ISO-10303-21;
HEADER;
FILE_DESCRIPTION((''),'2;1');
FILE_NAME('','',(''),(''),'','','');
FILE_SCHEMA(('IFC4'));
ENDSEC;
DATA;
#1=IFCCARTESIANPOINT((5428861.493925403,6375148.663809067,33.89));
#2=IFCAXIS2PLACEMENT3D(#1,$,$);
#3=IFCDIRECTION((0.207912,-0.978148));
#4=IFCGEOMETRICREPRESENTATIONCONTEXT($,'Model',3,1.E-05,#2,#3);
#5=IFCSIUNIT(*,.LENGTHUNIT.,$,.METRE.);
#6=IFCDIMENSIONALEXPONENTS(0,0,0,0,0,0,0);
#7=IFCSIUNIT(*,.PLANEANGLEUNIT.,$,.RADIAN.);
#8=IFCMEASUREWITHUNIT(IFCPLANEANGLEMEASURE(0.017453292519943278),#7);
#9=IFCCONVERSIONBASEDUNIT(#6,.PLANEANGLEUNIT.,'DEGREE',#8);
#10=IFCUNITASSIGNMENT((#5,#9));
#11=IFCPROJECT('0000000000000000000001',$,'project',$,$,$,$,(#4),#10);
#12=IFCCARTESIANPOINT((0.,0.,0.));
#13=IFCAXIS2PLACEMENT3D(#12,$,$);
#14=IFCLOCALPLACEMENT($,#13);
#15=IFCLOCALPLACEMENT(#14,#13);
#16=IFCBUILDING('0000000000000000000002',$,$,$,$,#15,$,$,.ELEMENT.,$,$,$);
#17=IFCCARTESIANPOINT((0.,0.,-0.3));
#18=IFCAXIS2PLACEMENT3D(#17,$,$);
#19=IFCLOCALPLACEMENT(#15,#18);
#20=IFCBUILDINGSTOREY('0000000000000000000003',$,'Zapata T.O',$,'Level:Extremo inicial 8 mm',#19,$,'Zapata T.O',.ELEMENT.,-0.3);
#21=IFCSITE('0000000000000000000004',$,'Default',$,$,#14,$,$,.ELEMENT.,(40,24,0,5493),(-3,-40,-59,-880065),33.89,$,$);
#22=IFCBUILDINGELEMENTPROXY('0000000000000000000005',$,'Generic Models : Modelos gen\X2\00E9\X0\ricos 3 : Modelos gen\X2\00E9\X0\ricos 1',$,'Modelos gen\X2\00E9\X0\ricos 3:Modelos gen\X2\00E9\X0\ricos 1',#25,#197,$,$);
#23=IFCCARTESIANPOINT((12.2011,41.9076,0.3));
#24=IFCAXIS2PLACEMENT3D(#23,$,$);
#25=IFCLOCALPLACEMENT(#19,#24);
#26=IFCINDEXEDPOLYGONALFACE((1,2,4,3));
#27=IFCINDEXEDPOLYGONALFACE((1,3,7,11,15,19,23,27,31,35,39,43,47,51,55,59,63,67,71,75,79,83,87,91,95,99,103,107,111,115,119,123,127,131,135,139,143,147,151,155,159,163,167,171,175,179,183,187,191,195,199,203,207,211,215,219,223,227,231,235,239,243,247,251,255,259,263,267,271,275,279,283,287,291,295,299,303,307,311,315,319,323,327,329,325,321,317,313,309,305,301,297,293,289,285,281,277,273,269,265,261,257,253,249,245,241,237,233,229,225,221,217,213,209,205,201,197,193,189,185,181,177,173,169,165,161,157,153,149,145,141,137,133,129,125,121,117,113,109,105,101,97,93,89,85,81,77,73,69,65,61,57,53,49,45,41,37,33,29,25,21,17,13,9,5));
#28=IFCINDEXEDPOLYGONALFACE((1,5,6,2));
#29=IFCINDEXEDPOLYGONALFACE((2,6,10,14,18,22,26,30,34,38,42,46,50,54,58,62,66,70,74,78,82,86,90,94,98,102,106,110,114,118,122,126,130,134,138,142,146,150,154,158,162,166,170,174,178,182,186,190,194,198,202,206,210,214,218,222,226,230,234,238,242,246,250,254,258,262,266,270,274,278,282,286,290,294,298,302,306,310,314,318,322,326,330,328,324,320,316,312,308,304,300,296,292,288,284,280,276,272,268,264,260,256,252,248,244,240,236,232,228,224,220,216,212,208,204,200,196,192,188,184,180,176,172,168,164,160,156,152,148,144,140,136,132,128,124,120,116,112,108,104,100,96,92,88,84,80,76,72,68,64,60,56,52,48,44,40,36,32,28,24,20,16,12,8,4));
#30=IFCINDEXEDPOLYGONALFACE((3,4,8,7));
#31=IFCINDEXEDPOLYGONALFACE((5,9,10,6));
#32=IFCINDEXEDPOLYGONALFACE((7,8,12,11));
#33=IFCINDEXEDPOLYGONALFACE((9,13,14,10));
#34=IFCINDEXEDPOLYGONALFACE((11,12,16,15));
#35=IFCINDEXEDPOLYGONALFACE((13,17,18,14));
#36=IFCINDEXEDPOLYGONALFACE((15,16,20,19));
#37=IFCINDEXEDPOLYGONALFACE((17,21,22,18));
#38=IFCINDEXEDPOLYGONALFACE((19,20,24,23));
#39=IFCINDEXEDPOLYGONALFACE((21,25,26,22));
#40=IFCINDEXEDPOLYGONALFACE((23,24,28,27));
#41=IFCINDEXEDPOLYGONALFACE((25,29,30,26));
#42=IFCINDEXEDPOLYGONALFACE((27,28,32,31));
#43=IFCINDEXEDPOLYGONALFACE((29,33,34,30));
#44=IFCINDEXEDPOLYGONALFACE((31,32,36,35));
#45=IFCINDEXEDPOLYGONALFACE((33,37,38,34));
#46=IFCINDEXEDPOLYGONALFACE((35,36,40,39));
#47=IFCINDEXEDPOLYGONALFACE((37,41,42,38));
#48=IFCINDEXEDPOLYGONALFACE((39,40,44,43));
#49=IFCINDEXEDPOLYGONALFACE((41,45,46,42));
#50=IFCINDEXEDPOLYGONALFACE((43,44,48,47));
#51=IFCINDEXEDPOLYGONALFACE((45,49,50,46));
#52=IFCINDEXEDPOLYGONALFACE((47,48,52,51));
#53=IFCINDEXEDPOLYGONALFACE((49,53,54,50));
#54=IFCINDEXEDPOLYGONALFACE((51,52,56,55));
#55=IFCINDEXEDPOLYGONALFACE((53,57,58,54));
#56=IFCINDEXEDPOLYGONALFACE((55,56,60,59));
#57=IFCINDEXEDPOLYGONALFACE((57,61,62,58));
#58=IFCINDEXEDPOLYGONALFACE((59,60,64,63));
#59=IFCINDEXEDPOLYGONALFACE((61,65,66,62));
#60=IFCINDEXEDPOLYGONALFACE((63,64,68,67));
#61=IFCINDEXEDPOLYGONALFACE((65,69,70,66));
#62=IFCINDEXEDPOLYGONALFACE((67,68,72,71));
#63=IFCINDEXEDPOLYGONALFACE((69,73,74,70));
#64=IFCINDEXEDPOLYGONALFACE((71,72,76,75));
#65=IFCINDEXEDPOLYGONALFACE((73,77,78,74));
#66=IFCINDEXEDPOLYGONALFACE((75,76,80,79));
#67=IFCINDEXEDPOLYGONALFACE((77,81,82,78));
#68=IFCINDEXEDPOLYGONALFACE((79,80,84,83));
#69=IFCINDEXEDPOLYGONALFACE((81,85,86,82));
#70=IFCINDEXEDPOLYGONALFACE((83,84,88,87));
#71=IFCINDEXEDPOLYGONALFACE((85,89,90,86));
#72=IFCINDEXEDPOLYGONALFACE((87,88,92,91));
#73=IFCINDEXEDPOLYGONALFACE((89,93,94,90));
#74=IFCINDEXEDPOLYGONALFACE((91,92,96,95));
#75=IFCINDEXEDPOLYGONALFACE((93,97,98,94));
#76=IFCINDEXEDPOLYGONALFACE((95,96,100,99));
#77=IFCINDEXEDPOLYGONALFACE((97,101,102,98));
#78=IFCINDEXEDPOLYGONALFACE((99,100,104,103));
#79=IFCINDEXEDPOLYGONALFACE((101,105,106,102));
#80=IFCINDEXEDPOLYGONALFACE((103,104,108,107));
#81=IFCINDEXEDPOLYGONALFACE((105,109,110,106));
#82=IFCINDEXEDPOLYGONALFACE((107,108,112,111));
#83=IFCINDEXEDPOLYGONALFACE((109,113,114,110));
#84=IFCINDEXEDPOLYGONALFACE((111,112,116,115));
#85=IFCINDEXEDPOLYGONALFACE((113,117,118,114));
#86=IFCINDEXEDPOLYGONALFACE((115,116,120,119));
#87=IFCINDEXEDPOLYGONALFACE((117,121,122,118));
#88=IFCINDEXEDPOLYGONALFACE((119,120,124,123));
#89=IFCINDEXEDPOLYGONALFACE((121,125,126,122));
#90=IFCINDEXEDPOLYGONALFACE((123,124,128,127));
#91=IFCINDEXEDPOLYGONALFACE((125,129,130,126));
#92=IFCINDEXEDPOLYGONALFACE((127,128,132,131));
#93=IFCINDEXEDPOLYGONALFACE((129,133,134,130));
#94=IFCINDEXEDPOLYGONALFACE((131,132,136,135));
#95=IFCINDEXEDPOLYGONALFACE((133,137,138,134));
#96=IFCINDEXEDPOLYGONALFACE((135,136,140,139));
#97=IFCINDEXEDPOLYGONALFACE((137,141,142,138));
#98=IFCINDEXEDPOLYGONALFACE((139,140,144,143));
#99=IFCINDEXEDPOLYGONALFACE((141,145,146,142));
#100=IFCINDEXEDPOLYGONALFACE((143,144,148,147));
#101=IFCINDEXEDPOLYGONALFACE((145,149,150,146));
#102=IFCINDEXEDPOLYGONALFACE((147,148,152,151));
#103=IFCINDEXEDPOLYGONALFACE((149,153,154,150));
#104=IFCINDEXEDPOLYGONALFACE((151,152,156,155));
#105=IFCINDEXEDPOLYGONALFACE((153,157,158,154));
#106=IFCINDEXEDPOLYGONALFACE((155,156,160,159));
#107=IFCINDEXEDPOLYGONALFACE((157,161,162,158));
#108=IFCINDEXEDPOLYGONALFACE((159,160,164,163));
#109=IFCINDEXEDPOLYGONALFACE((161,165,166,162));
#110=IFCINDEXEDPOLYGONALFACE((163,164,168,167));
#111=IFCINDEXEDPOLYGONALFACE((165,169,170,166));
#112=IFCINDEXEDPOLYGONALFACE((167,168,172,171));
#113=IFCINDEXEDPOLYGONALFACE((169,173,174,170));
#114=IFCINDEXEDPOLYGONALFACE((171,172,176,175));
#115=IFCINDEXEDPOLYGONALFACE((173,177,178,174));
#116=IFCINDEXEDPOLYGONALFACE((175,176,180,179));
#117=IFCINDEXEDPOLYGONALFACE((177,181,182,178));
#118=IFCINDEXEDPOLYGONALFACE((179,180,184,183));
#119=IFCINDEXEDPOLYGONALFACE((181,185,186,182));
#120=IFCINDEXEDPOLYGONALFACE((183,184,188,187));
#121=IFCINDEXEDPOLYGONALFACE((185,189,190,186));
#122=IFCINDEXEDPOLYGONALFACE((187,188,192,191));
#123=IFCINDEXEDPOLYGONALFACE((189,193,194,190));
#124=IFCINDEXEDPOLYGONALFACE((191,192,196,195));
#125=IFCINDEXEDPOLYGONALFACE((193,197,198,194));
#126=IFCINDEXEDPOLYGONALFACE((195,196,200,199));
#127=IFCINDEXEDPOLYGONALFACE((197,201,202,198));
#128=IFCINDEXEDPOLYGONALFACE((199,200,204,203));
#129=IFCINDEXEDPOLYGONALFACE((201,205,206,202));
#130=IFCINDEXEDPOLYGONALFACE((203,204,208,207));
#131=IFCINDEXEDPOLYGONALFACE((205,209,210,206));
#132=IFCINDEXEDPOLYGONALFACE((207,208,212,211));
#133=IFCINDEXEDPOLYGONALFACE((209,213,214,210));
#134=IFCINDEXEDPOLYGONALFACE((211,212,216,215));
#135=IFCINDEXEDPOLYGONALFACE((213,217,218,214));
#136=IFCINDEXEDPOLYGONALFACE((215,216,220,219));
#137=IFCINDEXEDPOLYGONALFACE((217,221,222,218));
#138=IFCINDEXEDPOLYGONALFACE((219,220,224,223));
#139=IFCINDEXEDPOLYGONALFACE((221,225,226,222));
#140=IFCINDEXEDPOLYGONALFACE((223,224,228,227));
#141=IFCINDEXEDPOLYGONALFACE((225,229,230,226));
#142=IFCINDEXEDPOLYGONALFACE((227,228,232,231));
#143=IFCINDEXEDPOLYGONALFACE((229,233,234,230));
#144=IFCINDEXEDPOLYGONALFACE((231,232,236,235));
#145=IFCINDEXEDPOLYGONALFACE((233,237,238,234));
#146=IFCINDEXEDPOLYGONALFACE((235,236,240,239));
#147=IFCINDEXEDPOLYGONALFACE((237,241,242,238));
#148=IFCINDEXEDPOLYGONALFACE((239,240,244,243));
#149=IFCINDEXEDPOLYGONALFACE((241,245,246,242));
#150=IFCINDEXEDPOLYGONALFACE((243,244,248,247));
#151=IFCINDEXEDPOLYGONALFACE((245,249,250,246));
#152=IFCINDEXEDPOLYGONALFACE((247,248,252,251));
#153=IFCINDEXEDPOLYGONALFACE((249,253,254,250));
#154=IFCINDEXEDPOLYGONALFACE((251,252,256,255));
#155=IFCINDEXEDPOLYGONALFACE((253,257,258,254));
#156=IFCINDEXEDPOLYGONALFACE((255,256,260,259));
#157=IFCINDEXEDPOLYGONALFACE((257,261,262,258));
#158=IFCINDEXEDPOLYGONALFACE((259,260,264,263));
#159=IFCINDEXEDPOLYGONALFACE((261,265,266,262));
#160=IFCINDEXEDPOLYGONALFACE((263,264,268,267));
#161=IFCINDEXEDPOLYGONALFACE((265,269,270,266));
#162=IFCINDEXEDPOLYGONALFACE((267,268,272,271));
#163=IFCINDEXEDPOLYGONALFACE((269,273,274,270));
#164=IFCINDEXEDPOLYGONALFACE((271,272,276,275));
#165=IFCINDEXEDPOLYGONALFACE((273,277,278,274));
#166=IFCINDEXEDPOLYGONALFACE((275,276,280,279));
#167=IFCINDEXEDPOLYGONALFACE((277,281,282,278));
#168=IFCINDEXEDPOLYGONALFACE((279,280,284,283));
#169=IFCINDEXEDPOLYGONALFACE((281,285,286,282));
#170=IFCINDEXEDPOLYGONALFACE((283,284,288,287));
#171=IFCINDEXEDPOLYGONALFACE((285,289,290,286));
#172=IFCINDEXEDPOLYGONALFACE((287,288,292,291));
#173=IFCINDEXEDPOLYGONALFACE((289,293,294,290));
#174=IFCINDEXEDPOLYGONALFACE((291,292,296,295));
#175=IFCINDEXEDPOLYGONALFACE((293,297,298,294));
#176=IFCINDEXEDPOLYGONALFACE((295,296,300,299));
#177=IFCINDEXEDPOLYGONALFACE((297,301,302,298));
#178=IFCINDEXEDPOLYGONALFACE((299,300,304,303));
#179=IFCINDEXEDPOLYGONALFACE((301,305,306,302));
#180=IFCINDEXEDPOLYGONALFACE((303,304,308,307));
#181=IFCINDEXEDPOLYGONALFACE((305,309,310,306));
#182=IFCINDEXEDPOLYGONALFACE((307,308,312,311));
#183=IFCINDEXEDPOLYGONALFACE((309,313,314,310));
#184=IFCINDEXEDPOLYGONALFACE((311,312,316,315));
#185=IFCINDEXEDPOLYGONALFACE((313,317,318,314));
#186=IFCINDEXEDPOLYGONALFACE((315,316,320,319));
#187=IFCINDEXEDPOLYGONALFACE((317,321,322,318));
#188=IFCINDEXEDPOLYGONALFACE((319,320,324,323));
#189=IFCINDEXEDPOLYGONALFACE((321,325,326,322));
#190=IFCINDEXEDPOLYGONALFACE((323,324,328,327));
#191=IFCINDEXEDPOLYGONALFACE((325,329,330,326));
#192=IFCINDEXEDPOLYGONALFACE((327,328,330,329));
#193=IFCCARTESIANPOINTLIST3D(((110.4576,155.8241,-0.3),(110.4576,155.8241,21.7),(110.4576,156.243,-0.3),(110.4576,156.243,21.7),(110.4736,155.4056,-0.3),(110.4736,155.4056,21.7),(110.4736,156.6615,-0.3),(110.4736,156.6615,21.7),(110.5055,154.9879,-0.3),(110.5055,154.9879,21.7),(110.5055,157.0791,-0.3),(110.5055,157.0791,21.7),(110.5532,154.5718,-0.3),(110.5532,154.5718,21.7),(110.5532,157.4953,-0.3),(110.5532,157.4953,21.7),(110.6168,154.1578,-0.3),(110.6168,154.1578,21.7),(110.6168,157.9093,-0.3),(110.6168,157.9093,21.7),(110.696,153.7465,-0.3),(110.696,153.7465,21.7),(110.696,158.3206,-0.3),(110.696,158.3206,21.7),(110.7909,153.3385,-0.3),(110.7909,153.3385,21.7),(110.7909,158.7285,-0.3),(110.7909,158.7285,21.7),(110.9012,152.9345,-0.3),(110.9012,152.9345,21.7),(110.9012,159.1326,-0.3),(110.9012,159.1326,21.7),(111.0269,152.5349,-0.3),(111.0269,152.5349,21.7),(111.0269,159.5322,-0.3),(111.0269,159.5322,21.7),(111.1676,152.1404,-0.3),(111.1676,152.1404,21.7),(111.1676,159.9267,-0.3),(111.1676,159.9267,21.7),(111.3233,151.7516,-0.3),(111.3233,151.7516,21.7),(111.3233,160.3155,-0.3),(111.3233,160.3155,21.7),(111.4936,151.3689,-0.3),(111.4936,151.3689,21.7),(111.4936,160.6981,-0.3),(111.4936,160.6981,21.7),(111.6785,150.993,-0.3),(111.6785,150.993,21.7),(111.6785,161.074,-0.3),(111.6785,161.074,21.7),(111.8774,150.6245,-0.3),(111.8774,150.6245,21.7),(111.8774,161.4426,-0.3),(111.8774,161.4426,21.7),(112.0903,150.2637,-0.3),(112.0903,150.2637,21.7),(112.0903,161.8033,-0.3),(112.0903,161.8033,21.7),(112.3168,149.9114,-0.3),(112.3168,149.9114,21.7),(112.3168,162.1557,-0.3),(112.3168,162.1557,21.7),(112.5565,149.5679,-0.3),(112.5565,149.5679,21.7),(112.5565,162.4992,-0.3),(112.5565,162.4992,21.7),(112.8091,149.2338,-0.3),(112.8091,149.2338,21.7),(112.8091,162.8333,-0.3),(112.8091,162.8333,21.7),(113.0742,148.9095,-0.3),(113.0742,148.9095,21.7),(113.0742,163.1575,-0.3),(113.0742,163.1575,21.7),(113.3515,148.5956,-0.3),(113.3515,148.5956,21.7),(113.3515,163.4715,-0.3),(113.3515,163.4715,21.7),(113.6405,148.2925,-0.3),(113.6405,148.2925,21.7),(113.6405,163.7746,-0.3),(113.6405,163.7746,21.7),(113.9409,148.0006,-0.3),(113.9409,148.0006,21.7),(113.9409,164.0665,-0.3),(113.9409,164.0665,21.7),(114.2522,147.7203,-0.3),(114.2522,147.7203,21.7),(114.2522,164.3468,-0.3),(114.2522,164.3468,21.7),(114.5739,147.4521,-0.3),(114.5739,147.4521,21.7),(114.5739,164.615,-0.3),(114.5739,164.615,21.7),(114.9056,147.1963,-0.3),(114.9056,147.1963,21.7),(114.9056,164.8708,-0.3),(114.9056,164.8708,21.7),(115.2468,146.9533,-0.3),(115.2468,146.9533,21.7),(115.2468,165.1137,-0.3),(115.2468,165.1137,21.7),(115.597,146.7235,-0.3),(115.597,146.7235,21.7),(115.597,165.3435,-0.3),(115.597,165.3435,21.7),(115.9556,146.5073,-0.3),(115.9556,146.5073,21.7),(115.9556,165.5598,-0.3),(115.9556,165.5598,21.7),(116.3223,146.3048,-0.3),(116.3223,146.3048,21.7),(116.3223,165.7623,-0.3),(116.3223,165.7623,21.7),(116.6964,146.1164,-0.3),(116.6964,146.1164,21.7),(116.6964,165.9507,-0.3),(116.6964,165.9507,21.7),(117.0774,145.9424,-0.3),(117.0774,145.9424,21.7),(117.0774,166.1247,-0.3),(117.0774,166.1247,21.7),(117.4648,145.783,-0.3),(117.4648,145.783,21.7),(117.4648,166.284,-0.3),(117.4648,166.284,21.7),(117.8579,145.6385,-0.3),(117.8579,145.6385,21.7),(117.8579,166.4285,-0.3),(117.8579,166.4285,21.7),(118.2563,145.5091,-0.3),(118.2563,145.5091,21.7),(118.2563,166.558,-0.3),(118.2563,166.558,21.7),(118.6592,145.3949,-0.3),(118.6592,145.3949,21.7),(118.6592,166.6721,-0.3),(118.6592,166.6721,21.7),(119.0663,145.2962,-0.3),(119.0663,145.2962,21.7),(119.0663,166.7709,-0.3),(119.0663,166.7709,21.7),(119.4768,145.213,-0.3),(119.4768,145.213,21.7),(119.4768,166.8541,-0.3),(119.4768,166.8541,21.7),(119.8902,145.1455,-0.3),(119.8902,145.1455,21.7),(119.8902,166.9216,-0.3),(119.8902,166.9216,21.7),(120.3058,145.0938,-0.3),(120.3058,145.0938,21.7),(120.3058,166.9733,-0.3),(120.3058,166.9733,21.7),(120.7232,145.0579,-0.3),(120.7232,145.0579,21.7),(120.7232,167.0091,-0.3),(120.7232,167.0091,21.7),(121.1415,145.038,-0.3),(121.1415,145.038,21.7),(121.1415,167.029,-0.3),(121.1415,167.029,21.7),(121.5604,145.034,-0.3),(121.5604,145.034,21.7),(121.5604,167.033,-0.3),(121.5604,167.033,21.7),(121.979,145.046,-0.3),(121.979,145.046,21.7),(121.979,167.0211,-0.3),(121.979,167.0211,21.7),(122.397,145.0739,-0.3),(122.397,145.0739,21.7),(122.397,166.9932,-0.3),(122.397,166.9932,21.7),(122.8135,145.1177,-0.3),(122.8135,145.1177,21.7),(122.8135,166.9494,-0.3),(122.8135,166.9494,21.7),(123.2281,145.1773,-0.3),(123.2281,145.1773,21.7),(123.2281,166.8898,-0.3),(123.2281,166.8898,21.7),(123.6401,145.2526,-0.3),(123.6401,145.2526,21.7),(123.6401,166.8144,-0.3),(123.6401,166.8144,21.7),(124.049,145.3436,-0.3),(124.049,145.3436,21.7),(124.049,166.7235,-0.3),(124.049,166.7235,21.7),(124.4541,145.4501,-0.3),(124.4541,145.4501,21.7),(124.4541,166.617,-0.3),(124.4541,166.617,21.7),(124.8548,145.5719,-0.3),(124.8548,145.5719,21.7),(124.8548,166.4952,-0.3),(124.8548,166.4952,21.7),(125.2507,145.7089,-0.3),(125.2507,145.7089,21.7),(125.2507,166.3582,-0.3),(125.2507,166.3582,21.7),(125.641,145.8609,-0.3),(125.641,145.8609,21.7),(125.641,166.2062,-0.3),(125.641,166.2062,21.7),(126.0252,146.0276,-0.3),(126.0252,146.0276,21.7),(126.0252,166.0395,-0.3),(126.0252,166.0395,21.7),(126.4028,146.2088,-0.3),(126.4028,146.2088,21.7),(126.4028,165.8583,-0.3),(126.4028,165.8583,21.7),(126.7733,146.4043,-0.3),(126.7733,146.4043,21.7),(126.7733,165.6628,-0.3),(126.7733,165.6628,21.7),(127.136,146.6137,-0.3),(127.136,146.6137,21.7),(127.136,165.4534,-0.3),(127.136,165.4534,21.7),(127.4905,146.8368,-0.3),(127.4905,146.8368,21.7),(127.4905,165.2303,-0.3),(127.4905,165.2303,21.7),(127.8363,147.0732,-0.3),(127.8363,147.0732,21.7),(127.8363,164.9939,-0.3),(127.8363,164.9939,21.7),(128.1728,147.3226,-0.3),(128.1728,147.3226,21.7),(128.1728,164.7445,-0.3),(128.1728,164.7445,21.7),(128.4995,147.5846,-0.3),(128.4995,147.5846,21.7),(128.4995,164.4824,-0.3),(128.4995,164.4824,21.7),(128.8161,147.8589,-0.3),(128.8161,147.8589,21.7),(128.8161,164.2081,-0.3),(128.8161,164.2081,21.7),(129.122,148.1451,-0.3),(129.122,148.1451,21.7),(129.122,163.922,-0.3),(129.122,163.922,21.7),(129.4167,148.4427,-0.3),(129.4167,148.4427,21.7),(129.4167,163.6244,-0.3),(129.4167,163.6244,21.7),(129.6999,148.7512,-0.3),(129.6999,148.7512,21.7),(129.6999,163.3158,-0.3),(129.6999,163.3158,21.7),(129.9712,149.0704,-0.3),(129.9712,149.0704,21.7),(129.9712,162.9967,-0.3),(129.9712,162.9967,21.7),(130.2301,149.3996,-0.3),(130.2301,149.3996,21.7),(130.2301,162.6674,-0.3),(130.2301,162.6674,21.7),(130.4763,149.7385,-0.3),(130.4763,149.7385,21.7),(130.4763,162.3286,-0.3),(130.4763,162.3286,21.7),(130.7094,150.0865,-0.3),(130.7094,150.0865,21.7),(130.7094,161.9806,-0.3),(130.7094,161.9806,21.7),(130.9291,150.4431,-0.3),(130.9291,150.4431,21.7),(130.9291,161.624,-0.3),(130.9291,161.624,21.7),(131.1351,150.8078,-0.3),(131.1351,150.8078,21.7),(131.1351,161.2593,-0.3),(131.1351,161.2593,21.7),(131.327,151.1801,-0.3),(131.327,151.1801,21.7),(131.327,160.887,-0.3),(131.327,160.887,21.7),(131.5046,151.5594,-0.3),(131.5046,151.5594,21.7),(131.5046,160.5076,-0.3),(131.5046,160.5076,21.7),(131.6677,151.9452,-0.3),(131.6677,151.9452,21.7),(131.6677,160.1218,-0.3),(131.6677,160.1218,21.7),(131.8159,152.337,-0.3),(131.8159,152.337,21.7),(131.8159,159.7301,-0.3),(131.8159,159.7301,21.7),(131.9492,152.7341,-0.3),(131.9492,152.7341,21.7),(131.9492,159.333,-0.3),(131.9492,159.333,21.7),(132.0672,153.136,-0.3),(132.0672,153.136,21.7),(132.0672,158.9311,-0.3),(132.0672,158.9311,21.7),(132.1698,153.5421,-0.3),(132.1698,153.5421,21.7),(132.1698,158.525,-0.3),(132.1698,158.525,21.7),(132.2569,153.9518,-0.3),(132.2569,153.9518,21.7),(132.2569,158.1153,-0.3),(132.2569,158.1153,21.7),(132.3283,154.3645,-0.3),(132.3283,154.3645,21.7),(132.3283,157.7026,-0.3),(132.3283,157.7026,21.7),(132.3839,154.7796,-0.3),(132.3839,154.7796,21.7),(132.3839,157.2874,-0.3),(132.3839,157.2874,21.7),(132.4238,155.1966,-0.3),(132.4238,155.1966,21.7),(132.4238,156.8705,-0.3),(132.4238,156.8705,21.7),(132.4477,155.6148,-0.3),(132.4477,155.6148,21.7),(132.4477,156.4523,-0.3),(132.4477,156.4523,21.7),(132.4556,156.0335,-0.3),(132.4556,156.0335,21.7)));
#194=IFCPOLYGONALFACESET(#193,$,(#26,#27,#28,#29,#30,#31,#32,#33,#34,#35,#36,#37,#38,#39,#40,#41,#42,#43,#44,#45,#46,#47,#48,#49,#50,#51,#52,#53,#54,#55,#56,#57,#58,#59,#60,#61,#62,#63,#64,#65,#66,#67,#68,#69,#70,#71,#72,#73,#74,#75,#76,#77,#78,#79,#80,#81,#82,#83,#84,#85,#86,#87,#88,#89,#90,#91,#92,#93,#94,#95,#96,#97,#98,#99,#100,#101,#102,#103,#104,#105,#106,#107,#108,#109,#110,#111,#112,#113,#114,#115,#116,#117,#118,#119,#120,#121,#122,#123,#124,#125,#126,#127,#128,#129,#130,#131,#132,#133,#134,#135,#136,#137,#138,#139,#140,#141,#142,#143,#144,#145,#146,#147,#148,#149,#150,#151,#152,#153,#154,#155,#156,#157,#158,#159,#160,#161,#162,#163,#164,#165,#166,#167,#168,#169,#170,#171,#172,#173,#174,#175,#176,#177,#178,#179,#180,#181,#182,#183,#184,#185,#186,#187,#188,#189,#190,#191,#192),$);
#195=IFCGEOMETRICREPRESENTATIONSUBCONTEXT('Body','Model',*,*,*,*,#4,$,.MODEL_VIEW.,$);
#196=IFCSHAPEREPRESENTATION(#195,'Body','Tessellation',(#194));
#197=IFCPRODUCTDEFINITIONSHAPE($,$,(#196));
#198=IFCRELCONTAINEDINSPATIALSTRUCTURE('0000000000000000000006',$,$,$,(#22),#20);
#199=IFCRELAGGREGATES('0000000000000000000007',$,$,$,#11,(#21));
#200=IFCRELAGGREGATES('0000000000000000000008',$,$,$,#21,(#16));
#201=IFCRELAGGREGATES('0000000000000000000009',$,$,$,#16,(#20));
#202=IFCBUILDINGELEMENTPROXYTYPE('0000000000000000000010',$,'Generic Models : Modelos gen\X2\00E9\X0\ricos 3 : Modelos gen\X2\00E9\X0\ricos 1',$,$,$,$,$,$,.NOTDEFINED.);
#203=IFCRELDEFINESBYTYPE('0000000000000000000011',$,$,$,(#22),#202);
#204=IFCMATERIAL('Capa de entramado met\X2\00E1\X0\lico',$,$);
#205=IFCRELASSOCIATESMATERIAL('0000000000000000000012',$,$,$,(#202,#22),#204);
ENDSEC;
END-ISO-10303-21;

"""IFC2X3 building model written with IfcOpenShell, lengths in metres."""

from ifc_helpers import new_model, entity, si_unit, converted_unit, direction, frame, frame_2d, origin, place, context, subcontext, project, spatial, circle, extrude, source, transform, mapped, material, type_object, type_shapes, element, save


model = new_model("IFC2X3")

# Units and contexts
model_context = context("Model", 3, precision=1e-05, world=frame((5428861.493925403, 6375148.663809067, 33.89)), true_north=direction((0.207912, -0.978148)))
body_context = subcontext(model_context, "Body", "Model", "MODEL_VIEW")
ifc_project = project(units=[si_unit("LENGTHUNIT", "METRE"), converted_unit("PLANEANGLEUNIT", "DEGREE", entity("IfcPlaneAngleMeasure", 0.017453292519943278), si_unit("PLANEANGLEUNIT", "RADIAN"), dimensions=[0, 0, 0, 0, 0, 0, 0])], contexts=[model_context])

# Site, building, storey
site_placement = place(None, origin())
site = spatial("IfcSite", under=ifc_project, at=site_placement, Name="Default", CompositionType="ELEMENT", RefLatitude=(40, 24, 0, 5493), RefLongitude=(-3, -40, -59, -880065), RefElevation=33.89)
building_placement = place(site_placement, origin())
building = spatial("IfcBuilding", under=site, at=building_placement, CompositionType="ELEMENT")
storey_placement = place(building_placement, frame((0.0, 0.0, -0.3)))
storey = spatial("IfcBuildingStorey", under=building, at=storey_placement, Name="Zapata T.O", ObjectType="Level:Extremo inicial 8 mm", LongName="Zapata T.O", CompositionType="ELEMENT", Elevation=-0.3)

# Building element proxy
ifc_material = material(Name="Capa de entramado metálico")
building_element_proxy_type_1 = type_object("IfcBuildingElementProxyType", Name="Generic Models : Modelos genéricos 3 : Modelos genéricos 1", PredefinedType="NOTDEFINED", material=ifc_material)
shared_shape_1 = source(origin(), body_context, "Body", "SweptSolid", [
    extrude(circle(Radius=11.0, at=frame_2d((0.0, 0.0), x_axis=(1.0, 0.0))), frame((121.4556, 156.0335, -0.3)), (0.0, 0.0, 1.0), 22.0),
])
type_shapes(building_element_proxy_type_1, [shared_shape_1])
proxy_1_placement = place(storey_placement, frame((12.2011, 41.9076, 0.3)))
element("IfcBuildingElementProxy", 1, at=proxy_1_placement, inside=storey, type_object=building_element_proxy_type_1, material=ifc_material, Name="Generic Models : Modelos genéricos 3 : Modelos genéricos 1", ObjectType="Modelos genéricos 3:Modelos genéricos 1", context=body_context, shape_type="MappedRepresentation", body=[
    mapped(shared_shape_1, transform((0.0, 0.0, 0.0), scale=1.0)),
])

save(model, "model.ifc")
